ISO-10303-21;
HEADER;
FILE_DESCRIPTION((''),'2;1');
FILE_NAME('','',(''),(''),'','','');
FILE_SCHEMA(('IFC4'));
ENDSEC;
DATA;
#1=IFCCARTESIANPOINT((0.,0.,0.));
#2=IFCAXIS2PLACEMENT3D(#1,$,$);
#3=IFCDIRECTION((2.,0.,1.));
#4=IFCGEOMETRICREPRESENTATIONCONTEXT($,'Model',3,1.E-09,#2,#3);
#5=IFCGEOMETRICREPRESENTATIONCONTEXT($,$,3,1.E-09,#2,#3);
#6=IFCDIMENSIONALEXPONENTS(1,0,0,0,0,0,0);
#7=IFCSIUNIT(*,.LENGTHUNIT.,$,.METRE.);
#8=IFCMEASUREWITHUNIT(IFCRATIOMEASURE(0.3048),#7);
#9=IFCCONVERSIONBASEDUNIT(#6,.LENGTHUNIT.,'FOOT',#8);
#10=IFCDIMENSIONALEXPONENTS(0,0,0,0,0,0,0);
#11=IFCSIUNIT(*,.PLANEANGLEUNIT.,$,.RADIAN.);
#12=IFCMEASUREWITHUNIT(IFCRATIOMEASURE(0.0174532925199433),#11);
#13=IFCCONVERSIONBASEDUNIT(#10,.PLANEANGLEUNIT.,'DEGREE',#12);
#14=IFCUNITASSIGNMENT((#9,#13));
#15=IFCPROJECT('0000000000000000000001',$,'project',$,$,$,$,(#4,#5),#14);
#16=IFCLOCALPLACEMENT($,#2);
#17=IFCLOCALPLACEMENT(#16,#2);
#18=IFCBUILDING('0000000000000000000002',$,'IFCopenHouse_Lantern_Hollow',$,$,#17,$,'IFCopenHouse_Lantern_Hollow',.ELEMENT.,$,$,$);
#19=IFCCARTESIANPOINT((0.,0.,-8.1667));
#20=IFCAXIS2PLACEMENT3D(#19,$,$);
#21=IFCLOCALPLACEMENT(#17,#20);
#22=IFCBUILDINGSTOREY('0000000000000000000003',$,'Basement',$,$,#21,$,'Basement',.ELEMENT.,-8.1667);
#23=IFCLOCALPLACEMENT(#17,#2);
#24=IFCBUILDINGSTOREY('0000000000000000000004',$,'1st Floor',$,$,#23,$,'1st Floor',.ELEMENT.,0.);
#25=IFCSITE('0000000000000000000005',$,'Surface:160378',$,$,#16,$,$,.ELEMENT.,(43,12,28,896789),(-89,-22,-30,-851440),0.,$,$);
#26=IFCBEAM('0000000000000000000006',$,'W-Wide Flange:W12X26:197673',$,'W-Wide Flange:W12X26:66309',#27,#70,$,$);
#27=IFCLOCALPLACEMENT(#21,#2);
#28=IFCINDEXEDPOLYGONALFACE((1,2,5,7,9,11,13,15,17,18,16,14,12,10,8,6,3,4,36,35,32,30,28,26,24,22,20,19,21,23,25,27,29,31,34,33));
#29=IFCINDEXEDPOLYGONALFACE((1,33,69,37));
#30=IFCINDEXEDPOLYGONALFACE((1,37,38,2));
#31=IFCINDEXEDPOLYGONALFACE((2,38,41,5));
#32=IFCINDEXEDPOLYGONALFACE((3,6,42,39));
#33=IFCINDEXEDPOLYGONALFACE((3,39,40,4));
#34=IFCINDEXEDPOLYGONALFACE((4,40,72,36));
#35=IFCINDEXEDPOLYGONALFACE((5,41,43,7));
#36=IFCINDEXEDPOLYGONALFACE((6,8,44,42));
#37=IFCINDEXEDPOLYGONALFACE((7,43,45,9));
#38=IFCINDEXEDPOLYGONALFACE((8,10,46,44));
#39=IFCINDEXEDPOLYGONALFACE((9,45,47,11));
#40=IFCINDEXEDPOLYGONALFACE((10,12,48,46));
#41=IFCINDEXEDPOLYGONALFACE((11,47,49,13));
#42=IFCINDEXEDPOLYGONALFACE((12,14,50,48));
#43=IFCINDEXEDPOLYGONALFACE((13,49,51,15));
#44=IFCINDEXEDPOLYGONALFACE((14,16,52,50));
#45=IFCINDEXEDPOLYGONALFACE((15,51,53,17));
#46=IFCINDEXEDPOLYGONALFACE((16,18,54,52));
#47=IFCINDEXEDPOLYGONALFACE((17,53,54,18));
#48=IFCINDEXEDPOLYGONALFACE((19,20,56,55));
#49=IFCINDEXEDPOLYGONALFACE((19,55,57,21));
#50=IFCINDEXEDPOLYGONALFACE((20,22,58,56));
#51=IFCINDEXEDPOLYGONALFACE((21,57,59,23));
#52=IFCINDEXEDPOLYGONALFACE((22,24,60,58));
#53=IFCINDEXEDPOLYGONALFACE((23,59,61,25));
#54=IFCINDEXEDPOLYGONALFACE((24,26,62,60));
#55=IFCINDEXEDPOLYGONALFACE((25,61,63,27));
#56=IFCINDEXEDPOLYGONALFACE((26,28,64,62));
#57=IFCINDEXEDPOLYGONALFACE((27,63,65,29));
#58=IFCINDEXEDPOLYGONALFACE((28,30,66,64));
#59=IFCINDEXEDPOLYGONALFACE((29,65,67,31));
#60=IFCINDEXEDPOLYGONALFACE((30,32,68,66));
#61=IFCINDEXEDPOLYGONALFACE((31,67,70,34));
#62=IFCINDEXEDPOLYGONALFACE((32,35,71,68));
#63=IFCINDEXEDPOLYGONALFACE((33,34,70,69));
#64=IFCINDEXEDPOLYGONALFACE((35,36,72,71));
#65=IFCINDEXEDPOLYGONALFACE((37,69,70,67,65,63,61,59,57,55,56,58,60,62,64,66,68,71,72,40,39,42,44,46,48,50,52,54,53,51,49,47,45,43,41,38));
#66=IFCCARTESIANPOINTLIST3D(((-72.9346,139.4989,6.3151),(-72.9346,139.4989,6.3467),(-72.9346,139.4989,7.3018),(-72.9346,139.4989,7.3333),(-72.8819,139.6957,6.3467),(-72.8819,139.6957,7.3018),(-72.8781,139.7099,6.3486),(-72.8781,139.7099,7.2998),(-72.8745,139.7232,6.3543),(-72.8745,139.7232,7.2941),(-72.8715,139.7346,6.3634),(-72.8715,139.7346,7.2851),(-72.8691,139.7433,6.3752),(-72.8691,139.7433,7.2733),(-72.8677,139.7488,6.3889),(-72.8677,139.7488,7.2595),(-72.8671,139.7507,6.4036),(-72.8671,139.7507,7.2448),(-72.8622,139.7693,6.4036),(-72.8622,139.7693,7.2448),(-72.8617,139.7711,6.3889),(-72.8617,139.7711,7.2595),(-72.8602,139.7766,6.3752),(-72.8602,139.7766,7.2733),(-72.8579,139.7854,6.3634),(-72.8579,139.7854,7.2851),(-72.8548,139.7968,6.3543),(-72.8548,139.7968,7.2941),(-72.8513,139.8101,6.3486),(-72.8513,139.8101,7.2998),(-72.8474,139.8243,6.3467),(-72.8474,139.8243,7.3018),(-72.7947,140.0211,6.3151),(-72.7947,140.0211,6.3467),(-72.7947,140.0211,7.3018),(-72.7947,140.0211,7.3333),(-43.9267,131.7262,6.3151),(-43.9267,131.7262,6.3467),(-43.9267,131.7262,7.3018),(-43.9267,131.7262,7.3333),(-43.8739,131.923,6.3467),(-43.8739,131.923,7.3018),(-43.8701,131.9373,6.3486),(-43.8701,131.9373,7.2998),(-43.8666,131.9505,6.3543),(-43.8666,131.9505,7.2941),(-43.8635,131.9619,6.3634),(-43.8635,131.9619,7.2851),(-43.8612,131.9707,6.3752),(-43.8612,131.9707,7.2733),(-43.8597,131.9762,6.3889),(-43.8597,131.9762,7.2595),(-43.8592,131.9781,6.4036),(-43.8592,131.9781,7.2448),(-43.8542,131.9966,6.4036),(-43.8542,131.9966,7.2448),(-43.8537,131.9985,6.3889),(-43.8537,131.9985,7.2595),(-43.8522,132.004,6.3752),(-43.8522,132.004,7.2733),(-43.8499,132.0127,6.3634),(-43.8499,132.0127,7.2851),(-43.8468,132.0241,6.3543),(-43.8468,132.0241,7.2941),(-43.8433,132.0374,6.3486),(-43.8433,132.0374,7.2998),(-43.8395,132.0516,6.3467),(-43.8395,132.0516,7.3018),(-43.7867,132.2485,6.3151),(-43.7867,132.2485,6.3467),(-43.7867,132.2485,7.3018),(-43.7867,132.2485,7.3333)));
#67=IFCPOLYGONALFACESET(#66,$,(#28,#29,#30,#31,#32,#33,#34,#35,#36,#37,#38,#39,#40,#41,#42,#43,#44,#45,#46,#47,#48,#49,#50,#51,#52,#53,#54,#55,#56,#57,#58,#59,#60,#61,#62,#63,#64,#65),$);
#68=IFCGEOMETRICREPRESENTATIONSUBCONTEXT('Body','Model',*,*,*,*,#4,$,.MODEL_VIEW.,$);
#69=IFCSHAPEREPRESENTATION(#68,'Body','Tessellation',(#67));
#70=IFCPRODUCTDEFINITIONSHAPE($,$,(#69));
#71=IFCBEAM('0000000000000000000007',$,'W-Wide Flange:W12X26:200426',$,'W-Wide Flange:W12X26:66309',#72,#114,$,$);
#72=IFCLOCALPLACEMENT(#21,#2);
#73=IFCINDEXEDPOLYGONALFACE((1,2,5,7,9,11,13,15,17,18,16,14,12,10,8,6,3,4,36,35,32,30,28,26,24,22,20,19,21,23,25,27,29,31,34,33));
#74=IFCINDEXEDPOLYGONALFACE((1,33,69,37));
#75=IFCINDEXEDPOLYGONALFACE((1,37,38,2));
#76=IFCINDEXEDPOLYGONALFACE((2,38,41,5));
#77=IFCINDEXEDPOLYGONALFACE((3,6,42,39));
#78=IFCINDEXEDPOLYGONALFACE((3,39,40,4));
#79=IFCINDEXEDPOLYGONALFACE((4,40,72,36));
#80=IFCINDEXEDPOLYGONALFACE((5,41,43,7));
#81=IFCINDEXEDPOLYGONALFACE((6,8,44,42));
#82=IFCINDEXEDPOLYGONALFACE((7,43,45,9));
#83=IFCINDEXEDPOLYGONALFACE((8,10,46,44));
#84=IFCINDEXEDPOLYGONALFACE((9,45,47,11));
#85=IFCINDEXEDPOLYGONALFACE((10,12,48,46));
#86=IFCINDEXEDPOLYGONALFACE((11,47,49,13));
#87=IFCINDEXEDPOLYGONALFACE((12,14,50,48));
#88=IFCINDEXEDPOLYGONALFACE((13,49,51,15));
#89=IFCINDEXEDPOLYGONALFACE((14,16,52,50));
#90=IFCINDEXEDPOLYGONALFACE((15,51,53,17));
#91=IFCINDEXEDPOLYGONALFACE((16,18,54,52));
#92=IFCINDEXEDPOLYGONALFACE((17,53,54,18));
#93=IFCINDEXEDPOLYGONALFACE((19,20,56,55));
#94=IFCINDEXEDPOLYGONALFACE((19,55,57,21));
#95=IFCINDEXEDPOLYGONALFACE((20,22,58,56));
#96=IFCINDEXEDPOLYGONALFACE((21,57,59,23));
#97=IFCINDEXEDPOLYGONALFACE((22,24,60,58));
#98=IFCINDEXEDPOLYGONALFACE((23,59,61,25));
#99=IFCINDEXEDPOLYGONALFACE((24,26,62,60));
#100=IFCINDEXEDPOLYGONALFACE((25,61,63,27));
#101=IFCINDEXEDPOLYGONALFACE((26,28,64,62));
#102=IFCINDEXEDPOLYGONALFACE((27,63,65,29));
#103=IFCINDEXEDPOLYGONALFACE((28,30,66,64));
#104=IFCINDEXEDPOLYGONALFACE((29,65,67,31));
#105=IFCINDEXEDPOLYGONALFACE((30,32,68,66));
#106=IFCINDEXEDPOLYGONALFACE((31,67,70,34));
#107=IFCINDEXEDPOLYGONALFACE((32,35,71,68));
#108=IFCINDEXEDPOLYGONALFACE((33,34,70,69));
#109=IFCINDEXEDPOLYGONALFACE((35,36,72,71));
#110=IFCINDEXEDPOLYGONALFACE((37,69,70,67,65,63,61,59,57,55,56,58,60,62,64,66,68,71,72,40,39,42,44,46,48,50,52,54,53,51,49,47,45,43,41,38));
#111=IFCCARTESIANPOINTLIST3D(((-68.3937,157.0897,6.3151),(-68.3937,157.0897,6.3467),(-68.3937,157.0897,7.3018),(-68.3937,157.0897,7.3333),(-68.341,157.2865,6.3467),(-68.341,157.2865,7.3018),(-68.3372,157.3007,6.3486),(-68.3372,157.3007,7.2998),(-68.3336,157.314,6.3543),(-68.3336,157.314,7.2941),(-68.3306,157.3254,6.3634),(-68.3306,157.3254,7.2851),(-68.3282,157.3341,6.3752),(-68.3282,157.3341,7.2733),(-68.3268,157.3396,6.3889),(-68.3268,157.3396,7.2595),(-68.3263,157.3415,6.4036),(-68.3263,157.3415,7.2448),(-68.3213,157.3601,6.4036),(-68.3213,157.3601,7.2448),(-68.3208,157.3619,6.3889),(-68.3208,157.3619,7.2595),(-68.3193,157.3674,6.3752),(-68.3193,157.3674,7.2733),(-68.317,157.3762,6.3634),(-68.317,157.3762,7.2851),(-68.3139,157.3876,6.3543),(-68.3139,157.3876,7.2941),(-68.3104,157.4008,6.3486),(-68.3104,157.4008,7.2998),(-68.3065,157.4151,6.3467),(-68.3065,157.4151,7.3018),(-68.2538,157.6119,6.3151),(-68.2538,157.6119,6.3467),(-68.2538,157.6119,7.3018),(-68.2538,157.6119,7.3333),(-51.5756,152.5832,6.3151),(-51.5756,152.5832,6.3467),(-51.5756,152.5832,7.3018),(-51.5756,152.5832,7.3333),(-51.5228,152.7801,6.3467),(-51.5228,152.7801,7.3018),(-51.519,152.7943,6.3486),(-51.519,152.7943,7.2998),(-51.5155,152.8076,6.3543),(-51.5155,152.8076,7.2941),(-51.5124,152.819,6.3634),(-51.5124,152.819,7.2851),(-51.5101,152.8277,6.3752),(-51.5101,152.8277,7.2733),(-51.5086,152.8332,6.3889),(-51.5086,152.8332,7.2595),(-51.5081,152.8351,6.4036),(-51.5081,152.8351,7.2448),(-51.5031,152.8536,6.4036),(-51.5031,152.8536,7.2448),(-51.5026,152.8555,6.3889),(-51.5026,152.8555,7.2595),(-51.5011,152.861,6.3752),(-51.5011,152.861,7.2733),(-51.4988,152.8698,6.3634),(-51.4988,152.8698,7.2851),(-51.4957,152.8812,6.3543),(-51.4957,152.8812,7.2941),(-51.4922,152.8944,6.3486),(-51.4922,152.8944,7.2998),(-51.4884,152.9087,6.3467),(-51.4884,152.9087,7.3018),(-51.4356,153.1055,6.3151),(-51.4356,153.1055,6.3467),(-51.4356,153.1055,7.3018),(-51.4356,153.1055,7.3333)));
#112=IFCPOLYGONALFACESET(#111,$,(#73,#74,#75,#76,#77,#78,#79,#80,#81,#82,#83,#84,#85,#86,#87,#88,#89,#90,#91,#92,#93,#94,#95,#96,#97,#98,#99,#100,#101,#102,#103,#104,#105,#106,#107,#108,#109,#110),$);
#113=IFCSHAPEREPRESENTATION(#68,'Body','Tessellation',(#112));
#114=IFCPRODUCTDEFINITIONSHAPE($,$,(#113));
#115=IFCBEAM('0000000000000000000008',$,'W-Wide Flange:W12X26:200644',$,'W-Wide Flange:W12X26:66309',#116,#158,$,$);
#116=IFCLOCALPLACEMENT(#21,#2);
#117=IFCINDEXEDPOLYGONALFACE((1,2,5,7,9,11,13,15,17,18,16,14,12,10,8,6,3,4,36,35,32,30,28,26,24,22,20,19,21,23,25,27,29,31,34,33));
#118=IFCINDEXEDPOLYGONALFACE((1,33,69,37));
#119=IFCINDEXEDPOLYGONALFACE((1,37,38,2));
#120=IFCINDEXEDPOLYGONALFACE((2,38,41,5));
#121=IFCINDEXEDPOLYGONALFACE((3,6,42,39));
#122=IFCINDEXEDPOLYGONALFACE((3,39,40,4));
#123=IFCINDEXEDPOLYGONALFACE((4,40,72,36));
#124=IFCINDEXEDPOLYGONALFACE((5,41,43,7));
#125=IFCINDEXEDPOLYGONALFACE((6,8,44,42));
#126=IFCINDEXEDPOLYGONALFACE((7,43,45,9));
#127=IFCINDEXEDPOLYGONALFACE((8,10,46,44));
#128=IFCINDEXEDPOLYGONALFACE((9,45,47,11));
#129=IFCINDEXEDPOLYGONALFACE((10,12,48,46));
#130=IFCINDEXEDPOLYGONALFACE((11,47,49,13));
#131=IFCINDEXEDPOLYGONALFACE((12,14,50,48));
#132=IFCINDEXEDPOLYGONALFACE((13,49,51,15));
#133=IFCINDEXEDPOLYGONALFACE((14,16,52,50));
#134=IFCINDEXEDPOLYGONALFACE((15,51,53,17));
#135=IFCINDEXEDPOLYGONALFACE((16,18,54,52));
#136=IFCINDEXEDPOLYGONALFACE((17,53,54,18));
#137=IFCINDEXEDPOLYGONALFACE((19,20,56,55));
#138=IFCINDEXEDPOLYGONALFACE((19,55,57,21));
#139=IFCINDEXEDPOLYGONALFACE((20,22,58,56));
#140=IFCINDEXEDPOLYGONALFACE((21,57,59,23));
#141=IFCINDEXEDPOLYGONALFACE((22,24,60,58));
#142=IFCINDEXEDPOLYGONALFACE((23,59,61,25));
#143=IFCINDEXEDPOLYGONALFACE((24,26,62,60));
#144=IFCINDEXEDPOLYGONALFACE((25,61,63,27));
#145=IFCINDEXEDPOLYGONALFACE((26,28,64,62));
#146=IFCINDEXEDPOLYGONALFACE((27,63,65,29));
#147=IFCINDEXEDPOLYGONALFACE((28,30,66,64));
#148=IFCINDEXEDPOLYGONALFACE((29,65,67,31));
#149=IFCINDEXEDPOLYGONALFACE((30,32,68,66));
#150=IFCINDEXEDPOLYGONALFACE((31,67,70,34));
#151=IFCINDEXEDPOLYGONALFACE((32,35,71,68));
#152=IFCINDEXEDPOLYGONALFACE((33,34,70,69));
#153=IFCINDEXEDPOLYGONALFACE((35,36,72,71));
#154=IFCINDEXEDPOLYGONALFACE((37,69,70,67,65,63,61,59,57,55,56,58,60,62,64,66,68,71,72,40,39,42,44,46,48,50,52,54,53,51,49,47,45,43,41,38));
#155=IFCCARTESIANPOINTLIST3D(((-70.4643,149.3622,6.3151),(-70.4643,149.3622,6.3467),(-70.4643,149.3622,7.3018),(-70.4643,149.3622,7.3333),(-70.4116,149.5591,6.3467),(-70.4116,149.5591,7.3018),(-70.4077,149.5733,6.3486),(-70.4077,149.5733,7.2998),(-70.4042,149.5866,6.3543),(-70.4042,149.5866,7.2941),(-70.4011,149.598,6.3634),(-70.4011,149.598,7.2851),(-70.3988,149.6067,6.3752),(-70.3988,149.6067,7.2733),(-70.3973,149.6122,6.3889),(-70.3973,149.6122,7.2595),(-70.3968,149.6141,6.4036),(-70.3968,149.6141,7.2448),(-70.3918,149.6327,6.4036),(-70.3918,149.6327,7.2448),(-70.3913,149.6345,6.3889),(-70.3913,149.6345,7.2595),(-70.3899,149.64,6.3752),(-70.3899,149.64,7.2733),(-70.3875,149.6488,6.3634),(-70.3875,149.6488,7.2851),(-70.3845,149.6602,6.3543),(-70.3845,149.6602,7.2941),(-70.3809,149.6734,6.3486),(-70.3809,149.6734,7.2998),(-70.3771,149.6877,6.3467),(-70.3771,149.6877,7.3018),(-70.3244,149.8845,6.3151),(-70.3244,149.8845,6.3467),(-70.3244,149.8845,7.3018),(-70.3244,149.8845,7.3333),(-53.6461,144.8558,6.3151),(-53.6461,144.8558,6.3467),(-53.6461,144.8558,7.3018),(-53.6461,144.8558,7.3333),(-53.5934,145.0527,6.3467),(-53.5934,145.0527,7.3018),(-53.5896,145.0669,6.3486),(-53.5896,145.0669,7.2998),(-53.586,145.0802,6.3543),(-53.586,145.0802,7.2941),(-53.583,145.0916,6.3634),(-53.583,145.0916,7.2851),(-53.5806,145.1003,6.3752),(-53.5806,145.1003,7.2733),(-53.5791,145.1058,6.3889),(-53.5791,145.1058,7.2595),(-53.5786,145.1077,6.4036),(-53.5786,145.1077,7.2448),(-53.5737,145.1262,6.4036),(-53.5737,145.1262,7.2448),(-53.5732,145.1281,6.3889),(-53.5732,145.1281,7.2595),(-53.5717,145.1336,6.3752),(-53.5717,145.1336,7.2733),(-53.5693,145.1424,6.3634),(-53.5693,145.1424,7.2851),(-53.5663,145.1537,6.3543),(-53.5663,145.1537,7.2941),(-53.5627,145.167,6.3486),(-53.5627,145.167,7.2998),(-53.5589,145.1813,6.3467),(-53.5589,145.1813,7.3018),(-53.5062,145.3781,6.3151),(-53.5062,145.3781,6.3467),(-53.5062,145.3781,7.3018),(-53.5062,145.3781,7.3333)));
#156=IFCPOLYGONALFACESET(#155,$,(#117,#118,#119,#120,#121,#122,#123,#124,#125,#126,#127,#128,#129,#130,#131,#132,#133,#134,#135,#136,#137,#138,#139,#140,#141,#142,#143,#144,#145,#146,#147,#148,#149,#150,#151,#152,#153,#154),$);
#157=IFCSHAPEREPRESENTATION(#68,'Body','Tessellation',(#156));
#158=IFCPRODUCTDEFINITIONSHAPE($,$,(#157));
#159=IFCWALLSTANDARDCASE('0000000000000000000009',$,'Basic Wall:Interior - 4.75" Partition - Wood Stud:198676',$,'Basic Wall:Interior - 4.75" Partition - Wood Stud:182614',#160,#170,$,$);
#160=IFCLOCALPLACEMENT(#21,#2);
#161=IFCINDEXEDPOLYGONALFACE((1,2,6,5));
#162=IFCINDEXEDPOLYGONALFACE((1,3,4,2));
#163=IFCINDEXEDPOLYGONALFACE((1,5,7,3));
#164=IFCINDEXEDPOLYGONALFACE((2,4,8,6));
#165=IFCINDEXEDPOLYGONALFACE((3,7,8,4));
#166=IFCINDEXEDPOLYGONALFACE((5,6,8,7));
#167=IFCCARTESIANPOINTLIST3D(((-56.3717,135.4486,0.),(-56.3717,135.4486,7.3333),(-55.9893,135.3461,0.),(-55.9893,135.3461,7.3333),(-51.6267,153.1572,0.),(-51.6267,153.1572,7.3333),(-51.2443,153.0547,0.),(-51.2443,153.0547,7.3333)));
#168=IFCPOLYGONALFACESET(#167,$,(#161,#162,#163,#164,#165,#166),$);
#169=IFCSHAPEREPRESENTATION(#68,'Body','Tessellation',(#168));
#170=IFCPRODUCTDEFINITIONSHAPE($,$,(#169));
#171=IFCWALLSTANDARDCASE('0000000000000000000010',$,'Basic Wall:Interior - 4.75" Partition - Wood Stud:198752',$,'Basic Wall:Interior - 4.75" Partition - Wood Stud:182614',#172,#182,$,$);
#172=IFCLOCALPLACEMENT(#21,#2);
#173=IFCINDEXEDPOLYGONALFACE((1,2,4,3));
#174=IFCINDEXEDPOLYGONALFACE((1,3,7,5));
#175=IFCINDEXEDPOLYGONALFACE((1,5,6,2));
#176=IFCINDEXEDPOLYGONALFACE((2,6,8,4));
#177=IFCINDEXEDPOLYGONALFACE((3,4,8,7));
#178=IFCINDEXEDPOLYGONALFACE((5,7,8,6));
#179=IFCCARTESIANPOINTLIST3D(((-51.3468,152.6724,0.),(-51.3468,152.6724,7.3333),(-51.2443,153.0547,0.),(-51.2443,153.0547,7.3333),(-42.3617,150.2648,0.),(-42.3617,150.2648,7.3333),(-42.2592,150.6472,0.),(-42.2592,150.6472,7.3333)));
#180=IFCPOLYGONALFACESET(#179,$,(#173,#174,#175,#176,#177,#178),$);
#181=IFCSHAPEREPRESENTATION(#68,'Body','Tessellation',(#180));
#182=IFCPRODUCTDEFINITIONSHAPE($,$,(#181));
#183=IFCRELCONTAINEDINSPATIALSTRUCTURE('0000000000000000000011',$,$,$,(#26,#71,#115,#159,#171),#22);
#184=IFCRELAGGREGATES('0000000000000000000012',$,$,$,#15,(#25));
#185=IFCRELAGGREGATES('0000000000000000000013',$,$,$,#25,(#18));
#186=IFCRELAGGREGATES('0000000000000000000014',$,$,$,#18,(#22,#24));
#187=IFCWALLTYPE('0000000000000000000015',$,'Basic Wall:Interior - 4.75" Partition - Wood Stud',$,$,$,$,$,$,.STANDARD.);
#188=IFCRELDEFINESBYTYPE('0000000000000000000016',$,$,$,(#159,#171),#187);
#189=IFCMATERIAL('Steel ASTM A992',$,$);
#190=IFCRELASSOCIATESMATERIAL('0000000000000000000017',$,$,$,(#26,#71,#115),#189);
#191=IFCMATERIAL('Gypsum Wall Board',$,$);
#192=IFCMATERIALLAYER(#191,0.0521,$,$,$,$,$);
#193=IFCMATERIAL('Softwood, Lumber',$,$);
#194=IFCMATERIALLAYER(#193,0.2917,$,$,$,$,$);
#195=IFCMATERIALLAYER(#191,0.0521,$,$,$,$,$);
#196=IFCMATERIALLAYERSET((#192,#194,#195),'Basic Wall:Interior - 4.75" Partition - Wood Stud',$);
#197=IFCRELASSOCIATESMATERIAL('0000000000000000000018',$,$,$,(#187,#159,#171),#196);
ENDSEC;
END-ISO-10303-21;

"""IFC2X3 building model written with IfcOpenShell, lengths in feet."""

from ifc_helpers import new_model, entity, si_unit, converted_unit, direction, frame, frame_2d, origin, place, context, subcontext, project, spatial, rectangle, i_section, extrude, material, layer, layer_set, layer_usage, type_object, element, save


model = new_model("IFC2X3")

# Units and contexts
model_context = context("Model", 3, precision=1e-09, world=origin(), true_north=direction((2.0, 0.0, 1.0)))
context_of_model = context(None, 3, precision=1e-09, world=origin(), true_north=direction((2.0, 0.0, 1.0)))
body_context = subcontext(model_context, "Body", "Model", "MODEL_VIEW")
ifc_project = project(units=[converted_unit("LENGTHUNIT", "FOOT", entity("IfcRatioMeasure", 0.3048), si_unit("LENGTHUNIT", "METRE"), dimensions=[1, 0, 0, 0, 0, 0, 0]), converted_unit("PLANEANGLEUNIT", "DEGREE", entity("IfcRatioMeasure", 0.0174532925199433), si_unit("PLANEANGLEUNIT", "RADIAN"), dimensions=[0, 0, 0, 0, 0, 0, 0])], contexts=[model_context, context_of_model])

# Site, building, storey
site_placement = place(None, origin())
site = spatial("IfcSite", under=ifc_project, at=site_placement, Name="Surface:160378", CompositionType="ELEMENT", RefLatitude=(43, 12, 28, 896789), RefLongitude=(-89, -22, -30, -851440), RefElevation=0.0)
building_placement = place(site_placement, origin())
building = spatial("IfcBuilding", under=site, at=building_placement, Name="IFCopenHouse_Lantern_Hollow", LongName="IFCopenHouse_Lantern_Hollow", CompositionType="ELEMENT")
storey_1_placement = place(building_placement, frame((0.0, 0.0, -8.1667)))
storey_1 = spatial("IfcBuildingStorey", under=building, at=storey_1_placement, Name="Basement", LongName="Basement", CompositionType="ELEMENT", Elevation=-8.1667)

# Beams
ifc_material_1 = material(Name="Steel ASTM A992")
beam_1_placement = place(storey_1_placement, frame((-72.8647, 139.76, 8.1667), z_axis=(0.0, 0.0, 1.0), x_axis=(0.965926, -0.258819, 0.0)))
element("IfcBeam", 1, at=beam_1_placement, inside=storey_1, material=ifc_material_1, Name="W-Wide Flange:W12X26:197673", ObjectType="W-Wide Flange:W12X26:66309", context=body_context, shape_type="SweptSolid", body=[
    extrude(i_section(OverallWidth=0.5407, OverallDepth=1.0182, WebThickness=0.0192, FlangeThickness=0.0316, FilletRadius=0.057, at=frame_2d((0.0, 0.0), x_axis=(0.0, 1.0))), frame((0.0, 0.0, -1.3424), z_axis=(1.0, 0.0, 0.0), x_axis=(0.0, 0.0, -1.0)), (0.0, 0.0, 1.0), 30.0313),
])
beam_2_placement = place(storey_1_placement, frame((-68.3238, 157.3508, 8.1667), z_axis=(0.0, 0.0, 1.0), x_axis=(0.965926, -0.258819, 0.0)))
element("IfcBeam", 2, at=beam_2_placement, inside=storey_1, material=ifc_material_1, Name="W-Wide Flange:W12X26:200426", ObjectType="W-Wide Flange:W12X26:66309", context=body_context, shape_type="SweptSolid", body=[
    extrude(i_section(OverallWidth=0.5407, OverallDepth=1.0182, WebThickness=0.0192, FlangeThickness=0.0316, FilletRadius=0.057, at=frame_2d((0.0, 0.0), x_axis=(0.0, 1.0))), frame((0.0, 0.0, -1.3424), z_axis=(1.0, 0.0, 0.0), x_axis=(0.0, 0.0, -1.0)), (0.0, 0.0, 1.0), 17.4115),
])
beam_3_placement = place(storey_1_placement, frame((-70.3943, 149.6234, 8.1667), z_axis=(0.0, 0.0, 1.0), x_axis=(0.965926, -0.258819, 0.0)))
element("IfcBeam", 3, at=beam_3_placement, inside=storey_1, material=ifc_material_1, Name="W-Wide Flange:W12X26:200644", ObjectType="W-Wide Flange:W12X26:66309", context=body_context, shape_type="SweptSolid", body=[
    extrude(i_section(OverallWidth=0.5407, OverallDepth=1.0182, WebThickness=0.0192, FlangeThickness=0.0316, FilletRadius=0.057, at=frame_2d((0.0, 0.0), x_axis=(0.0, 1.0))), frame((0.0, 0.0, -1.3424), z_axis=(1.0, 0.0, 0.0), x_axis=(0.0, 0.0, -1.0)), (0.0, 0.0, 1.0), 17.4115),
])

# Shared definitions
ifc_material_2 = material(Name="Softwood, Lumber")
ifc_material_3 = material(Name="Gypsum Wall Board")

# Walls
ifc_layer_1 = layer(ifc_material_3, 0.0521)
ifc_layer_2 = layer(ifc_material_2, 0.2917)
ifc_layer_3 = layer(ifc_material_3, 0.0521)
ifc_layer_set_1 = layer_set([ifc_layer_1, ifc_layer_2, ifc_layer_3], Name="Basic Wall:Interior - 4.75\" Partition - Wood Stud")
ifc_layer_usage_1 = layer_usage(ifc_layer_set_1, "AXIS2", "NEGATIVE", 0.1979)
wall_type_1 = type_object("IfcWallType", Name="Basic Wall:Interior - 4.75\" Partition - Wood Stud", PredefinedType="STANDARD", material=ifc_layer_set_1)
wall_1_placement = place(storey_1_placement, frame((-51.4355, 153.106, 0.0), z_axis=(0.0, 0.0, 1.0), x_axis=(-0.258819, -0.965926, 0.0)))
element("IfcWallStandardCase", 4, at=wall_1_placement, inside=storey_1, type_object=wall_type_1, material=ifc_layer_usage_1, Name="Basic Wall:Interior - 4.75\" Partition - Wood Stud:198676", ObjectType="Basic Wall:Interior - 4.75\" Partition - Wood Stud:182614", context=body_context, shape_type="SweptSolid", body=[
    extrude(rectangle(XDim=18.3333, YDim=0.3958, at=frame_2d((9.1667, 0.0), x_axis=(-1.0, 0.0))), origin(), (0.0, 0.0, 1.0), 7.3333),
])
ifc_layer_usage_2 = layer_usage(ifc_layer_set_1, "AXIS2", "NEGATIVE", 0.1979)
wall_2_placement = place(storey_1_placement, frame((-51.2956, 152.8636, 0.0), z_axis=(0.0, 0.0, 1.0), x_axis=(0.965926, -0.258819, 0.0)))
element("IfcWallStandardCase", 5, at=wall_2_placement, inside=storey_1, type_object=wall_type_1, material=ifc_layer_usage_2, Name="Basic Wall:Interior - 4.75\" Partition - Wood Stud:198752", ObjectType="Basic Wall:Interior - 4.75\" Partition - Wood Stud:182614", context=body_context, shape_type="SweptSolid", body=[
    extrude(rectangle(XDim=9.3021, YDim=0.3958, at=frame_2d((4.651, 0.0), x_axis=(-1.0, 0.0))), origin(), (0.0, 0.0, 1.0), 7.3333),
])

# Shared definitions
storey_2_placement = place(building_placement, origin())
storey_2 = spatial("IfcBuildingStorey", under=building, at=storey_2_placement, Name="1st Floor", LongName="1st Floor", CompositionType="ELEMENT", Elevation=0.0)

save(model, "model.ifc")
